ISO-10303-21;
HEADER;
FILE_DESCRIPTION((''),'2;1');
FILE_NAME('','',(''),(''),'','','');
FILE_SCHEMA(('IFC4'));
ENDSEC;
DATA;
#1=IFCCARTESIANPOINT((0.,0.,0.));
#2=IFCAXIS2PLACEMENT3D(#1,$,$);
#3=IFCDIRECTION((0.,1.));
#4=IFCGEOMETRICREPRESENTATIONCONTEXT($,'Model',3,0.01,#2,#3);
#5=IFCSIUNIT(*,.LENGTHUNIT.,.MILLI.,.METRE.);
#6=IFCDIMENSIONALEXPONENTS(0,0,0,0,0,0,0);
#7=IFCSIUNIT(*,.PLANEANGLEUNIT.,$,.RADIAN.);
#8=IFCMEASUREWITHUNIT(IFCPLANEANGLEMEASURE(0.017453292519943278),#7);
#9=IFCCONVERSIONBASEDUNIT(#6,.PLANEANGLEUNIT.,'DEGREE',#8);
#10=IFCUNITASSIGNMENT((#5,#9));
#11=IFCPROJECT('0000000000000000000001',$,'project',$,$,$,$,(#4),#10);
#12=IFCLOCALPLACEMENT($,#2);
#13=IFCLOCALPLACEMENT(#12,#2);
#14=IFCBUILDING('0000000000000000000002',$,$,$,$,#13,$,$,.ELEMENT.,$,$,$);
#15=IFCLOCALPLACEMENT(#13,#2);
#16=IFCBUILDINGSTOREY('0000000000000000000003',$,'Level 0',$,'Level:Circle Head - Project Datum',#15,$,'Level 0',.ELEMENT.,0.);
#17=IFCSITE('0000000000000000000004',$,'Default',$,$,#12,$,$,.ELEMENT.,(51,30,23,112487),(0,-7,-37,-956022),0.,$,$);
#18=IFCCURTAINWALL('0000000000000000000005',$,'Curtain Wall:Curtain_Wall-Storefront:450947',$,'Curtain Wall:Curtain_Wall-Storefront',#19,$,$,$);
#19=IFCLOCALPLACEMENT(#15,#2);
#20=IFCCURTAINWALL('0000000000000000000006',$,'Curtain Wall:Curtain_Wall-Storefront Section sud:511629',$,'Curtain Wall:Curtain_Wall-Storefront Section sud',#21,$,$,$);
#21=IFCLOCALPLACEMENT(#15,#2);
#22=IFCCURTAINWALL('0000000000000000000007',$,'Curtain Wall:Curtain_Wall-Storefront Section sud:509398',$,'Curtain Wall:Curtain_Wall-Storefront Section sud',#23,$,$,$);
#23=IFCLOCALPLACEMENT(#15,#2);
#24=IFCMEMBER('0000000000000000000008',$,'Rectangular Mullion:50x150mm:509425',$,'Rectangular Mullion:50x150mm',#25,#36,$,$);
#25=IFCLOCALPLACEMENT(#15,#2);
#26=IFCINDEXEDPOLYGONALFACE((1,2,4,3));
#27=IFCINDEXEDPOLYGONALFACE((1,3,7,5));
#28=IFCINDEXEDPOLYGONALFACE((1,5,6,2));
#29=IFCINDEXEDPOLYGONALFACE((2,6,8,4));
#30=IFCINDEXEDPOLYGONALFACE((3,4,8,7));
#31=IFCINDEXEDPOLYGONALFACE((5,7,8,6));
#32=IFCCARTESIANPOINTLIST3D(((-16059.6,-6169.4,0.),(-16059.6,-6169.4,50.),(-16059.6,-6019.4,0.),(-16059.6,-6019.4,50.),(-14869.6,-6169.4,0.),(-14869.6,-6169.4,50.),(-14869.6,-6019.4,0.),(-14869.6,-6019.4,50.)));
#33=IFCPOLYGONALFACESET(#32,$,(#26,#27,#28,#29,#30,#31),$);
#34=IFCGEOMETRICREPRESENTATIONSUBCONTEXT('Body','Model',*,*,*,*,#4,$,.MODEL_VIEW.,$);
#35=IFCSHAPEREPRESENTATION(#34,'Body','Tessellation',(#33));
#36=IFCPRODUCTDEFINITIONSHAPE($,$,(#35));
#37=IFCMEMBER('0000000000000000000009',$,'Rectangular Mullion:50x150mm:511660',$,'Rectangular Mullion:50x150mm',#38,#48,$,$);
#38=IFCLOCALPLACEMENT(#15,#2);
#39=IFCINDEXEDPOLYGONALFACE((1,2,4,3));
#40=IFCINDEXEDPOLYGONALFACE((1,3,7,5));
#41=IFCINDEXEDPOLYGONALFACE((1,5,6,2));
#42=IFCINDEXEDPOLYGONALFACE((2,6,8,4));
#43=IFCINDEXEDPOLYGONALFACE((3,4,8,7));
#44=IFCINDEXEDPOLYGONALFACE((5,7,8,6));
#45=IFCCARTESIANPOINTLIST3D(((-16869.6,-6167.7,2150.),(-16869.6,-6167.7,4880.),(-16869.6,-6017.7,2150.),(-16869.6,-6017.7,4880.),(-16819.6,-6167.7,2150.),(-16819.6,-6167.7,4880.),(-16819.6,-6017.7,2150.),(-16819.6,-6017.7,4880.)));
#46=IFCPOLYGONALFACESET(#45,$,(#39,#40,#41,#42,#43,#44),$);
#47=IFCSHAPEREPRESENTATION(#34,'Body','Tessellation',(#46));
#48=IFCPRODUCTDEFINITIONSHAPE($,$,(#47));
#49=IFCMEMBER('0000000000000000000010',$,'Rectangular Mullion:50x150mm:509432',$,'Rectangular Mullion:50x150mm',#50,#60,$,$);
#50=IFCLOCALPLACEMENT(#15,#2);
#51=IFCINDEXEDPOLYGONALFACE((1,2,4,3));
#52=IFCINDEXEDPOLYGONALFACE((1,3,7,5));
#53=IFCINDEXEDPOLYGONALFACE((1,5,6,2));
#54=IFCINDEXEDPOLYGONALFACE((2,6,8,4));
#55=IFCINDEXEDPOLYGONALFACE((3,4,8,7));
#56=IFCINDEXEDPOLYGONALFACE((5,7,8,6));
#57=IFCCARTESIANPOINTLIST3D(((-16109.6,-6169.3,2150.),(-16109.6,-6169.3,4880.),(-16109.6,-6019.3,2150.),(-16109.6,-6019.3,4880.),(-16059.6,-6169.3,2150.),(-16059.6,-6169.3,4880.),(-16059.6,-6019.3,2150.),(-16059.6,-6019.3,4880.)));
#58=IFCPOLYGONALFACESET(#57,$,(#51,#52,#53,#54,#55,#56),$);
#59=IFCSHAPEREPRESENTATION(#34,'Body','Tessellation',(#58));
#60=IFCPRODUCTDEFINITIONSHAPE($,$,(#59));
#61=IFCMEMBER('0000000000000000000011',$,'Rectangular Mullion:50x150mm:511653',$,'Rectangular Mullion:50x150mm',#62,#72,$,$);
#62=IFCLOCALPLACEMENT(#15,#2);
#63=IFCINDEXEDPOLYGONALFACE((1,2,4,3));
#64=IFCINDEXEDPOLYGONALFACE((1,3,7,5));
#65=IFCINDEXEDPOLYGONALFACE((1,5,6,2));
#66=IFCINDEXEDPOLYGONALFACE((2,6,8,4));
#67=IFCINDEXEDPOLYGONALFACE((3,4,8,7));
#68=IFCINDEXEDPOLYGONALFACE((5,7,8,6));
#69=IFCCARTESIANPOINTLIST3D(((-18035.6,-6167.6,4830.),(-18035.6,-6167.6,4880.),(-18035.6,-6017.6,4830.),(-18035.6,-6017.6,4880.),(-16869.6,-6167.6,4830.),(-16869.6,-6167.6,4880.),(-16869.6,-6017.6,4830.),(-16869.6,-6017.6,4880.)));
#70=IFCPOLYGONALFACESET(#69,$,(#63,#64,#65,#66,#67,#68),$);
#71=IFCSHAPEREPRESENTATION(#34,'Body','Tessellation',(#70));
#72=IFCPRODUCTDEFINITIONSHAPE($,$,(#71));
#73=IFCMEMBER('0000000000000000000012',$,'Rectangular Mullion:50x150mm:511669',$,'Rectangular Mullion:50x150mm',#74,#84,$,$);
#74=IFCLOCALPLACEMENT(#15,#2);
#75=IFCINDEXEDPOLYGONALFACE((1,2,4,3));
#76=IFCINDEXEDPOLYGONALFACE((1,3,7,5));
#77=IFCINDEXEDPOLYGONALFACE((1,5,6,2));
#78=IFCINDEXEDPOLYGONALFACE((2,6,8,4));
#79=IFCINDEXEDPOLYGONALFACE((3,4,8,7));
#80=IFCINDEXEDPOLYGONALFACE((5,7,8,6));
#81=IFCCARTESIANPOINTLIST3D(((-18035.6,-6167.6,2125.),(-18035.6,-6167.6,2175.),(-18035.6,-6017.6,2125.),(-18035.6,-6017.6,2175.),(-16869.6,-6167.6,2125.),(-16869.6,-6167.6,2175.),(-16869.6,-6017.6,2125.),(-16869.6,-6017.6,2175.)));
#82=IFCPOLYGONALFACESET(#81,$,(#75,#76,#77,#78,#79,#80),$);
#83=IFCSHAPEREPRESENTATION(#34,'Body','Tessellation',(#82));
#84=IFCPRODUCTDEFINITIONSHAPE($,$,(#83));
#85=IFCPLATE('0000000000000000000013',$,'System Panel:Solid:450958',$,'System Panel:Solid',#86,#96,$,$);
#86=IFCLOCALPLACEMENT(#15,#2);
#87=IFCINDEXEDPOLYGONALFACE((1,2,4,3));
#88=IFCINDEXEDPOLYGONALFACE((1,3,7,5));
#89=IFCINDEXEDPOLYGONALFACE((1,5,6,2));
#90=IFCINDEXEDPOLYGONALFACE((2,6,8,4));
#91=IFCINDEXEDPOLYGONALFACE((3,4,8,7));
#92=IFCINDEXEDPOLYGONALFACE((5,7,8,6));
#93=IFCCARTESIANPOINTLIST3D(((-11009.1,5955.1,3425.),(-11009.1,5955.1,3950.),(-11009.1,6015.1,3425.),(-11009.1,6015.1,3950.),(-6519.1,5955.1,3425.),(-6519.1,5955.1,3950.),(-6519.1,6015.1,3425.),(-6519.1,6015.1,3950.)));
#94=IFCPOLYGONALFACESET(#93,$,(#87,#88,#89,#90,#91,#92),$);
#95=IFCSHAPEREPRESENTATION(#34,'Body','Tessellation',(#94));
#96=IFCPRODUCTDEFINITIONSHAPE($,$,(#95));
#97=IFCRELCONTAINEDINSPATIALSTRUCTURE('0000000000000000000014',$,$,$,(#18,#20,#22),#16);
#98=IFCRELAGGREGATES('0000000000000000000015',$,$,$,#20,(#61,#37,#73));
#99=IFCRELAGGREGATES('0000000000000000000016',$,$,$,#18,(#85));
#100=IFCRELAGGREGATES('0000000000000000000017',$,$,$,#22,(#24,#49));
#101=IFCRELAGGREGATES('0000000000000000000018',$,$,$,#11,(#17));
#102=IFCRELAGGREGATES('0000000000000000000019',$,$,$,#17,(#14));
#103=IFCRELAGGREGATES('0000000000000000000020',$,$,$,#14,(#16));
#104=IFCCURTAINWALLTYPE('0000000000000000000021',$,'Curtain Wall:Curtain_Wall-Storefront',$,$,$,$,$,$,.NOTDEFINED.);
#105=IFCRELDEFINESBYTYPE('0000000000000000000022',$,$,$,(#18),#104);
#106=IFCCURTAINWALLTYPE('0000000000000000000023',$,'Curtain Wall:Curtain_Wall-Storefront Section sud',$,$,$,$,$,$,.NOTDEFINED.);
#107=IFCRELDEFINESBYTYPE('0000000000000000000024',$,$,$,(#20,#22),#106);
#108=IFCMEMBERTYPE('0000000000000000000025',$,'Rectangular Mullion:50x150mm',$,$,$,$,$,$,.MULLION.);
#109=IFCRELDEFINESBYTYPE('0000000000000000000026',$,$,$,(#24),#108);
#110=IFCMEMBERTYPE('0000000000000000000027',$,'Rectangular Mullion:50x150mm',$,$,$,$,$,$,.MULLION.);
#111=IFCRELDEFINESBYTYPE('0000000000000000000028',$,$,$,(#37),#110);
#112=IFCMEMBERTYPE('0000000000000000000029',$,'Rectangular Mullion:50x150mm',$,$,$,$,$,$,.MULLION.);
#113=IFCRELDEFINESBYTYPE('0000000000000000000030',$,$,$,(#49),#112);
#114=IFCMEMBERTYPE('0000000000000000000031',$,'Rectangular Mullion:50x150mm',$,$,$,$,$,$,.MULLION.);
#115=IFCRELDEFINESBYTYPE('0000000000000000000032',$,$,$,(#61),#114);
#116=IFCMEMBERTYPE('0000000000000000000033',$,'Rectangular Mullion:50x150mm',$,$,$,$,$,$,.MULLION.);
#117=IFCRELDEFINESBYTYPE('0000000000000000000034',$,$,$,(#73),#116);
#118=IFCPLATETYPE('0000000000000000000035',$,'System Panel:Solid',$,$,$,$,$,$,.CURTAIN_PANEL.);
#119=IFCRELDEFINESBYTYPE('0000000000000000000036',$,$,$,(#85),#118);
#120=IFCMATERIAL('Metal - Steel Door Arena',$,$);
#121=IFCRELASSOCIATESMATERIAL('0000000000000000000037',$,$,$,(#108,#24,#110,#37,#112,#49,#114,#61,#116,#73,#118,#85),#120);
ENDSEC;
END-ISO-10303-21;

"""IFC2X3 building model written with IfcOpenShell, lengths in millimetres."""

from ifc_helpers import new_model, entity, si_unit, converted_unit, direction, frame, frame_2d, origin, origin_2d_with_axis, place, context, subcontext, project, spatial, rectangle, extrude, source, transform, mapped, material, type_object, type_shapes, element, aggregate, save


model = new_model("IFC2X3")

# Units and contexts
model_context = context("Model", 3, precision=0.01, world=origin(), true_north=direction((0.0, 1.0)))
body_context = subcontext(model_context, "Body", "Model", "MODEL_VIEW")
ifc_project = project(units=[si_unit("LENGTHUNIT", "METRE", prefix="MILLI"), converted_unit("PLANEANGLEUNIT", "DEGREE", entity("IfcPlaneAngleMeasure", 0.017453292519943278), si_unit("PLANEANGLEUNIT", "RADIAN"), dimensions=[0, 0, 0, 0, 0, 0, 0])], contexts=[model_context])

# Site, building, storey
site_placement = place(None, origin())
site = spatial("IfcSite", under=ifc_project, at=site_placement, Name="Default", CompositionType="ELEMENT", RefLatitude=(51, 30, 23, 112487), RefLongitude=(0, -7, -37, -956022), RefElevation=0.0)
building_placement = place(site_placement, origin())
building = spatial("IfcBuilding", under=site, at=building_placement, CompositionType="ELEMENT")
storey_placement = place(building_placement, origin())
storey = spatial("IfcBuildingStorey", under=building, at=storey_placement, Name="Level 0", ObjectType="Level:Circle Head - Project Datum", LongName="Level 0", CompositionType="ELEMENT", Elevation=0.0)

# Curtain walls
curtain_wall_type_1 = type_object("IfcCurtainWallType", Name="Curtain Wall:Curtain_Wall-Storefront", PredefinedType="NOTDEFINED")
curtain_wall_1_placement = place(storey_placement, origin())
curtain_wall_1 = element("IfcCurtainWall", 1, at=curtain_wall_1_placement, inside=storey, type_object=curtain_wall_type_1, Name="Curtain Wall:Curtain_Wall-Storefront:450947", ObjectType="Curtain Wall:Curtain_Wall-Storefront")
ifc_material_1 = material(Name="Metal - Steel Door Arena")
curtain_wall_type_2 = type_object("IfcCurtainWallType", Name="Curtain Wall:Curtain_Wall-Storefront Section sud", PredefinedType="NOTDEFINED")
curtain_wall_2_placement = place(storey_placement, origin())
curtain_wall_2 = element("IfcCurtainWall", 2, at=curtain_wall_2_placement, inside=storey, type_object=curtain_wall_type_2, Name="Curtain Wall:Curtain_Wall-Storefront Section sud:511629", ObjectType="Curtain Wall:Curtain_Wall-Storefront Section sud")
curtain_wall_3_placement = place(storey_placement, origin())
curtain_wall_3 = element("IfcCurtainWall", 3, at=curtain_wall_3_placement, inside=storey, type_object=curtain_wall_type_2, Name="Curtain Wall:Curtain_Wall-Storefront Section sud:509398", ObjectType="Curtain Wall:Curtain_Wall-Storefront Section sud")

# Members
member_type_1 = type_object("IfcMemberType", Name="Rectangular Mullion:50x150mm", PredefinedType="MULLION", material=ifc_material_1)
shared_shape_1 = source(origin(), body_context, "Body", "SweptSolid", [
    extrude(rectangle(XDim=50.0, YDim=150.0, at=origin_2d_with_axis()), frame((-25.0, 0.0, -1190.0), z_axis=(0.0, 0.0, 1.0), x_axis=(-1.0, 0.0, 0.0)), (0.0, 0.0, 1.0), 1190.0),
])
type_shapes(member_type_1, [shared_shape_1])
member_1_placement = place(curtain_wall_3_placement, frame((-16059.6, -6094.4, 0.0), z_axis=(-1.0, 0.0, 0.0), x_axis=(0.0, 0.0, -1.0)))
member_1 = element("IfcMember", 4, at=member_1_placement, type_object=member_type_1, material=ifc_material_1, Name="Rectangular Mullion:50x150mm:509425", ObjectType="Rectangular Mullion:50x150mm", context=body_context, shape_type="MappedRepresentation", body=[
    mapped(shared_shape_1, transform((0.0, 0.0, 0.0), scale=1.0)),
])
member_type_2 = type_object("IfcMemberType", Name="Rectangular Mullion:50x150mm", PredefinedType="MULLION", material=ifc_material_1)
shared_shape_2 = source(origin(), body_context, "Body", "SweptSolid", [
    extrude(rectangle(XDim=50.0, YDim=150.0, at=origin_2d_with_axis()), frame((-25.0, 0.0, -2730.0), z_axis=(0.0, 0.0, 1.0), x_axis=(-1.0, 0.0, 0.0)), (0.0, 0.0, 1.0), 2730.0),
])
type_shapes(member_type_2, [shared_shape_2])
member_2_placement = place(curtain_wall_2_placement, frame((-16819.6, -6092.7, 2150.0), z_axis=(0.0, 0.0, -1.0), x_axis=(1.0, 0.0, 0.0)))
member_2 = element("IfcMember", 5, at=member_2_placement, type_object=member_type_2, material=ifc_material_1, Name="Rectangular Mullion:50x150mm:511660", ObjectType="Rectangular Mullion:50x150mm", context=body_context, shape_type="MappedRepresentation", body=[
    mapped(shared_shape_2, transform((0.0, 0.0, 0.0), scale=1.0)),
])
member_type_3 = type_object("IfcMemberType", Name="Rectangular Mullion:50x150mm", PredefinedType="MULLION", material=ifc_material_1)
shared_shape_3 = source(origin(), body_context, "Body", "SweptSolid", [
    extrude(rectangle(XDim=50.0, YDim=150.0, at=origin_2d_with_axis()), frame((-25.0, 0.0, -2730.0), z_axis=(0.0, 0.0, 1.0), x_axis=(-1.0, 0.0, 0.0)), (0.0, 0.0, 1.0), 2730.0),
])
type_shapes(member_type_3, [shared_shape_3])
member_3_placement = place(curtain_wall_3_placement, frame((-16109.6, -6094.3, 4880.0), z_axis=(0.0, 0.0, 1.0), x_axis=(-1.0, 0.0, 0.0)))
member_3 = element("IfcMember", 6, at=member_3_placement, type_object=member_type_3, material=ifc_material_1, Name="Rectangular Mullion:50x150mm:509432", ObjectType="Rectangular Mullion:50x150mm", context=body_context, shape_type="MappedRepresentation", body=[
    mapped(shared_shape_3, transform((0.0, 0.0, 0.0), scale=1.0)),
])
member_type_4 = type_object("IfcMemberType", Name="Rectangular Mullion:50x150mm", PredefinedType="MULLION", material=ifc_material_1)
shared_shape_4 = source(origin(), body_context, "Body", "SweptSolid", [
    extrude(rectangle(XDim=50.0, YDim=150.0, at=origin_2d_with_axis()), frame((-25.0, 0.0, -1166.0), z_axis=(0.0, 0.0, 1.0), x_axis=(-1.0, 0.0, 0.0)), (0.0, 0.0, 1.0), 1166.0),
])
type_shapes(member_type_4, [shared_shape_4])
member_4_placement = place(curtain_wall_2_placement, frame((-16869.6, -6092.6, 4880.0), z_axis=(1.0, 0.0, 0.0), x_axis=(0.0, 0.0, 1.0)))
member_4 = element("IfcMember", 7, at=member_4_placement, type_object=member_type_4, material=ifc_material_1, Name="Rectangular Mullion:50x150mm:511653", ObjectType="Rectangular Mullion:50x150mm", context=body_context, shape_type="MappedRepresentation", body=[
    mapped(shared_shape_4, transform((0.0, 0.0, 0.0), scale=1.0)),
])
member_type_5 = type_object("IfcMemberType", Name="Rectangular Mullion:50x150mm", PredefinedType="MULLION", material=ifc_material_1)
shared_shape_5 = source(origin(), body_context, "Body", "SweptSolid", [
    extrude(rectangle(XDim=50.0, YDim=150.0, at=origin_2d_with_axis()), frame((0.0, 0.0, -1166.0), z_axis=(0.0, 0.0, 1.0), x_axis=(-1.0, 0.0, 0.0)), (0.0, 0.0, 1.0), 1166.0),
])
type_shapes(member_type_5, [shared_shape_5])
member_5_placement = place(curtain_wall_2_placement, frame((-16869.6, -6092.6, 2150.0), z_axis=(1.0, 0.0, 0.0), x_axis=(0.0, 0.0, 1.0)))
member_5 = element("IfcMember", 8, at=member_5_placement, type_object=member_type_5, material=ifc_material_1, Name="Rectangular Mullion:50x150mm:511669", ObjectType="Rectangular Mullion:50x150mm", context=body_context, shape_type="MappedRepresentation", body=[
    mapped(shared_shape_5, transform((0.0, 0.0, 0.0), scale=1.0)),
])
aggregate(curtain_wall_2, [member_4, member_2, member_5])

# Plate
plate_type_1 = type_object("IfcPlateType", Name="System Panel:Solid", PredefinedType="CURTAIN_PANEL", material=ifc_material_1)
shared_shape_6 = source(origin(), body_context, "Body", "SweptSolid", [
    extrude(rectangle(XDim=525.0, YDim=4490.0, at=frame_2d((0.0, 0.0), x_axis=(1.0, 0.0))), frame((0.0, 15.0, 262.5), z_axis=(0.0, 1.0, 0.0), x_axis=(0.0, 0.0, 1.0)), (0.0, 0.0, 1.0), 60.0),
])
type_shapes(plate_type_1, [shared_shape_6])
plate_1_placement = place(curtain_wall_1_placement, frame((-8764.1, 6030.1, 3425.0), z_axis=(0.0, 0.0, 1.0), x_axis=(-1.0, 0.0, 0.0)))
plate_1 = element("IfcPlate", 9, at=plate_1_placement, type_object=plate_type_1, material=ifc_material_1, Name="System Panel:Solid:450958", ObjectType="System Panel:Solid", context=body_context, shape_type="MappedRepresentation", body=[
    mapped(shared_shape_6, transform((0.0, 0.0, 0.0), scale=1.0)),
])
aggregate(curtain_wall_1, [plate_1])
aggregate(curtain_wall_3, [member_1, member_3])

save(model, "model.ifc")
